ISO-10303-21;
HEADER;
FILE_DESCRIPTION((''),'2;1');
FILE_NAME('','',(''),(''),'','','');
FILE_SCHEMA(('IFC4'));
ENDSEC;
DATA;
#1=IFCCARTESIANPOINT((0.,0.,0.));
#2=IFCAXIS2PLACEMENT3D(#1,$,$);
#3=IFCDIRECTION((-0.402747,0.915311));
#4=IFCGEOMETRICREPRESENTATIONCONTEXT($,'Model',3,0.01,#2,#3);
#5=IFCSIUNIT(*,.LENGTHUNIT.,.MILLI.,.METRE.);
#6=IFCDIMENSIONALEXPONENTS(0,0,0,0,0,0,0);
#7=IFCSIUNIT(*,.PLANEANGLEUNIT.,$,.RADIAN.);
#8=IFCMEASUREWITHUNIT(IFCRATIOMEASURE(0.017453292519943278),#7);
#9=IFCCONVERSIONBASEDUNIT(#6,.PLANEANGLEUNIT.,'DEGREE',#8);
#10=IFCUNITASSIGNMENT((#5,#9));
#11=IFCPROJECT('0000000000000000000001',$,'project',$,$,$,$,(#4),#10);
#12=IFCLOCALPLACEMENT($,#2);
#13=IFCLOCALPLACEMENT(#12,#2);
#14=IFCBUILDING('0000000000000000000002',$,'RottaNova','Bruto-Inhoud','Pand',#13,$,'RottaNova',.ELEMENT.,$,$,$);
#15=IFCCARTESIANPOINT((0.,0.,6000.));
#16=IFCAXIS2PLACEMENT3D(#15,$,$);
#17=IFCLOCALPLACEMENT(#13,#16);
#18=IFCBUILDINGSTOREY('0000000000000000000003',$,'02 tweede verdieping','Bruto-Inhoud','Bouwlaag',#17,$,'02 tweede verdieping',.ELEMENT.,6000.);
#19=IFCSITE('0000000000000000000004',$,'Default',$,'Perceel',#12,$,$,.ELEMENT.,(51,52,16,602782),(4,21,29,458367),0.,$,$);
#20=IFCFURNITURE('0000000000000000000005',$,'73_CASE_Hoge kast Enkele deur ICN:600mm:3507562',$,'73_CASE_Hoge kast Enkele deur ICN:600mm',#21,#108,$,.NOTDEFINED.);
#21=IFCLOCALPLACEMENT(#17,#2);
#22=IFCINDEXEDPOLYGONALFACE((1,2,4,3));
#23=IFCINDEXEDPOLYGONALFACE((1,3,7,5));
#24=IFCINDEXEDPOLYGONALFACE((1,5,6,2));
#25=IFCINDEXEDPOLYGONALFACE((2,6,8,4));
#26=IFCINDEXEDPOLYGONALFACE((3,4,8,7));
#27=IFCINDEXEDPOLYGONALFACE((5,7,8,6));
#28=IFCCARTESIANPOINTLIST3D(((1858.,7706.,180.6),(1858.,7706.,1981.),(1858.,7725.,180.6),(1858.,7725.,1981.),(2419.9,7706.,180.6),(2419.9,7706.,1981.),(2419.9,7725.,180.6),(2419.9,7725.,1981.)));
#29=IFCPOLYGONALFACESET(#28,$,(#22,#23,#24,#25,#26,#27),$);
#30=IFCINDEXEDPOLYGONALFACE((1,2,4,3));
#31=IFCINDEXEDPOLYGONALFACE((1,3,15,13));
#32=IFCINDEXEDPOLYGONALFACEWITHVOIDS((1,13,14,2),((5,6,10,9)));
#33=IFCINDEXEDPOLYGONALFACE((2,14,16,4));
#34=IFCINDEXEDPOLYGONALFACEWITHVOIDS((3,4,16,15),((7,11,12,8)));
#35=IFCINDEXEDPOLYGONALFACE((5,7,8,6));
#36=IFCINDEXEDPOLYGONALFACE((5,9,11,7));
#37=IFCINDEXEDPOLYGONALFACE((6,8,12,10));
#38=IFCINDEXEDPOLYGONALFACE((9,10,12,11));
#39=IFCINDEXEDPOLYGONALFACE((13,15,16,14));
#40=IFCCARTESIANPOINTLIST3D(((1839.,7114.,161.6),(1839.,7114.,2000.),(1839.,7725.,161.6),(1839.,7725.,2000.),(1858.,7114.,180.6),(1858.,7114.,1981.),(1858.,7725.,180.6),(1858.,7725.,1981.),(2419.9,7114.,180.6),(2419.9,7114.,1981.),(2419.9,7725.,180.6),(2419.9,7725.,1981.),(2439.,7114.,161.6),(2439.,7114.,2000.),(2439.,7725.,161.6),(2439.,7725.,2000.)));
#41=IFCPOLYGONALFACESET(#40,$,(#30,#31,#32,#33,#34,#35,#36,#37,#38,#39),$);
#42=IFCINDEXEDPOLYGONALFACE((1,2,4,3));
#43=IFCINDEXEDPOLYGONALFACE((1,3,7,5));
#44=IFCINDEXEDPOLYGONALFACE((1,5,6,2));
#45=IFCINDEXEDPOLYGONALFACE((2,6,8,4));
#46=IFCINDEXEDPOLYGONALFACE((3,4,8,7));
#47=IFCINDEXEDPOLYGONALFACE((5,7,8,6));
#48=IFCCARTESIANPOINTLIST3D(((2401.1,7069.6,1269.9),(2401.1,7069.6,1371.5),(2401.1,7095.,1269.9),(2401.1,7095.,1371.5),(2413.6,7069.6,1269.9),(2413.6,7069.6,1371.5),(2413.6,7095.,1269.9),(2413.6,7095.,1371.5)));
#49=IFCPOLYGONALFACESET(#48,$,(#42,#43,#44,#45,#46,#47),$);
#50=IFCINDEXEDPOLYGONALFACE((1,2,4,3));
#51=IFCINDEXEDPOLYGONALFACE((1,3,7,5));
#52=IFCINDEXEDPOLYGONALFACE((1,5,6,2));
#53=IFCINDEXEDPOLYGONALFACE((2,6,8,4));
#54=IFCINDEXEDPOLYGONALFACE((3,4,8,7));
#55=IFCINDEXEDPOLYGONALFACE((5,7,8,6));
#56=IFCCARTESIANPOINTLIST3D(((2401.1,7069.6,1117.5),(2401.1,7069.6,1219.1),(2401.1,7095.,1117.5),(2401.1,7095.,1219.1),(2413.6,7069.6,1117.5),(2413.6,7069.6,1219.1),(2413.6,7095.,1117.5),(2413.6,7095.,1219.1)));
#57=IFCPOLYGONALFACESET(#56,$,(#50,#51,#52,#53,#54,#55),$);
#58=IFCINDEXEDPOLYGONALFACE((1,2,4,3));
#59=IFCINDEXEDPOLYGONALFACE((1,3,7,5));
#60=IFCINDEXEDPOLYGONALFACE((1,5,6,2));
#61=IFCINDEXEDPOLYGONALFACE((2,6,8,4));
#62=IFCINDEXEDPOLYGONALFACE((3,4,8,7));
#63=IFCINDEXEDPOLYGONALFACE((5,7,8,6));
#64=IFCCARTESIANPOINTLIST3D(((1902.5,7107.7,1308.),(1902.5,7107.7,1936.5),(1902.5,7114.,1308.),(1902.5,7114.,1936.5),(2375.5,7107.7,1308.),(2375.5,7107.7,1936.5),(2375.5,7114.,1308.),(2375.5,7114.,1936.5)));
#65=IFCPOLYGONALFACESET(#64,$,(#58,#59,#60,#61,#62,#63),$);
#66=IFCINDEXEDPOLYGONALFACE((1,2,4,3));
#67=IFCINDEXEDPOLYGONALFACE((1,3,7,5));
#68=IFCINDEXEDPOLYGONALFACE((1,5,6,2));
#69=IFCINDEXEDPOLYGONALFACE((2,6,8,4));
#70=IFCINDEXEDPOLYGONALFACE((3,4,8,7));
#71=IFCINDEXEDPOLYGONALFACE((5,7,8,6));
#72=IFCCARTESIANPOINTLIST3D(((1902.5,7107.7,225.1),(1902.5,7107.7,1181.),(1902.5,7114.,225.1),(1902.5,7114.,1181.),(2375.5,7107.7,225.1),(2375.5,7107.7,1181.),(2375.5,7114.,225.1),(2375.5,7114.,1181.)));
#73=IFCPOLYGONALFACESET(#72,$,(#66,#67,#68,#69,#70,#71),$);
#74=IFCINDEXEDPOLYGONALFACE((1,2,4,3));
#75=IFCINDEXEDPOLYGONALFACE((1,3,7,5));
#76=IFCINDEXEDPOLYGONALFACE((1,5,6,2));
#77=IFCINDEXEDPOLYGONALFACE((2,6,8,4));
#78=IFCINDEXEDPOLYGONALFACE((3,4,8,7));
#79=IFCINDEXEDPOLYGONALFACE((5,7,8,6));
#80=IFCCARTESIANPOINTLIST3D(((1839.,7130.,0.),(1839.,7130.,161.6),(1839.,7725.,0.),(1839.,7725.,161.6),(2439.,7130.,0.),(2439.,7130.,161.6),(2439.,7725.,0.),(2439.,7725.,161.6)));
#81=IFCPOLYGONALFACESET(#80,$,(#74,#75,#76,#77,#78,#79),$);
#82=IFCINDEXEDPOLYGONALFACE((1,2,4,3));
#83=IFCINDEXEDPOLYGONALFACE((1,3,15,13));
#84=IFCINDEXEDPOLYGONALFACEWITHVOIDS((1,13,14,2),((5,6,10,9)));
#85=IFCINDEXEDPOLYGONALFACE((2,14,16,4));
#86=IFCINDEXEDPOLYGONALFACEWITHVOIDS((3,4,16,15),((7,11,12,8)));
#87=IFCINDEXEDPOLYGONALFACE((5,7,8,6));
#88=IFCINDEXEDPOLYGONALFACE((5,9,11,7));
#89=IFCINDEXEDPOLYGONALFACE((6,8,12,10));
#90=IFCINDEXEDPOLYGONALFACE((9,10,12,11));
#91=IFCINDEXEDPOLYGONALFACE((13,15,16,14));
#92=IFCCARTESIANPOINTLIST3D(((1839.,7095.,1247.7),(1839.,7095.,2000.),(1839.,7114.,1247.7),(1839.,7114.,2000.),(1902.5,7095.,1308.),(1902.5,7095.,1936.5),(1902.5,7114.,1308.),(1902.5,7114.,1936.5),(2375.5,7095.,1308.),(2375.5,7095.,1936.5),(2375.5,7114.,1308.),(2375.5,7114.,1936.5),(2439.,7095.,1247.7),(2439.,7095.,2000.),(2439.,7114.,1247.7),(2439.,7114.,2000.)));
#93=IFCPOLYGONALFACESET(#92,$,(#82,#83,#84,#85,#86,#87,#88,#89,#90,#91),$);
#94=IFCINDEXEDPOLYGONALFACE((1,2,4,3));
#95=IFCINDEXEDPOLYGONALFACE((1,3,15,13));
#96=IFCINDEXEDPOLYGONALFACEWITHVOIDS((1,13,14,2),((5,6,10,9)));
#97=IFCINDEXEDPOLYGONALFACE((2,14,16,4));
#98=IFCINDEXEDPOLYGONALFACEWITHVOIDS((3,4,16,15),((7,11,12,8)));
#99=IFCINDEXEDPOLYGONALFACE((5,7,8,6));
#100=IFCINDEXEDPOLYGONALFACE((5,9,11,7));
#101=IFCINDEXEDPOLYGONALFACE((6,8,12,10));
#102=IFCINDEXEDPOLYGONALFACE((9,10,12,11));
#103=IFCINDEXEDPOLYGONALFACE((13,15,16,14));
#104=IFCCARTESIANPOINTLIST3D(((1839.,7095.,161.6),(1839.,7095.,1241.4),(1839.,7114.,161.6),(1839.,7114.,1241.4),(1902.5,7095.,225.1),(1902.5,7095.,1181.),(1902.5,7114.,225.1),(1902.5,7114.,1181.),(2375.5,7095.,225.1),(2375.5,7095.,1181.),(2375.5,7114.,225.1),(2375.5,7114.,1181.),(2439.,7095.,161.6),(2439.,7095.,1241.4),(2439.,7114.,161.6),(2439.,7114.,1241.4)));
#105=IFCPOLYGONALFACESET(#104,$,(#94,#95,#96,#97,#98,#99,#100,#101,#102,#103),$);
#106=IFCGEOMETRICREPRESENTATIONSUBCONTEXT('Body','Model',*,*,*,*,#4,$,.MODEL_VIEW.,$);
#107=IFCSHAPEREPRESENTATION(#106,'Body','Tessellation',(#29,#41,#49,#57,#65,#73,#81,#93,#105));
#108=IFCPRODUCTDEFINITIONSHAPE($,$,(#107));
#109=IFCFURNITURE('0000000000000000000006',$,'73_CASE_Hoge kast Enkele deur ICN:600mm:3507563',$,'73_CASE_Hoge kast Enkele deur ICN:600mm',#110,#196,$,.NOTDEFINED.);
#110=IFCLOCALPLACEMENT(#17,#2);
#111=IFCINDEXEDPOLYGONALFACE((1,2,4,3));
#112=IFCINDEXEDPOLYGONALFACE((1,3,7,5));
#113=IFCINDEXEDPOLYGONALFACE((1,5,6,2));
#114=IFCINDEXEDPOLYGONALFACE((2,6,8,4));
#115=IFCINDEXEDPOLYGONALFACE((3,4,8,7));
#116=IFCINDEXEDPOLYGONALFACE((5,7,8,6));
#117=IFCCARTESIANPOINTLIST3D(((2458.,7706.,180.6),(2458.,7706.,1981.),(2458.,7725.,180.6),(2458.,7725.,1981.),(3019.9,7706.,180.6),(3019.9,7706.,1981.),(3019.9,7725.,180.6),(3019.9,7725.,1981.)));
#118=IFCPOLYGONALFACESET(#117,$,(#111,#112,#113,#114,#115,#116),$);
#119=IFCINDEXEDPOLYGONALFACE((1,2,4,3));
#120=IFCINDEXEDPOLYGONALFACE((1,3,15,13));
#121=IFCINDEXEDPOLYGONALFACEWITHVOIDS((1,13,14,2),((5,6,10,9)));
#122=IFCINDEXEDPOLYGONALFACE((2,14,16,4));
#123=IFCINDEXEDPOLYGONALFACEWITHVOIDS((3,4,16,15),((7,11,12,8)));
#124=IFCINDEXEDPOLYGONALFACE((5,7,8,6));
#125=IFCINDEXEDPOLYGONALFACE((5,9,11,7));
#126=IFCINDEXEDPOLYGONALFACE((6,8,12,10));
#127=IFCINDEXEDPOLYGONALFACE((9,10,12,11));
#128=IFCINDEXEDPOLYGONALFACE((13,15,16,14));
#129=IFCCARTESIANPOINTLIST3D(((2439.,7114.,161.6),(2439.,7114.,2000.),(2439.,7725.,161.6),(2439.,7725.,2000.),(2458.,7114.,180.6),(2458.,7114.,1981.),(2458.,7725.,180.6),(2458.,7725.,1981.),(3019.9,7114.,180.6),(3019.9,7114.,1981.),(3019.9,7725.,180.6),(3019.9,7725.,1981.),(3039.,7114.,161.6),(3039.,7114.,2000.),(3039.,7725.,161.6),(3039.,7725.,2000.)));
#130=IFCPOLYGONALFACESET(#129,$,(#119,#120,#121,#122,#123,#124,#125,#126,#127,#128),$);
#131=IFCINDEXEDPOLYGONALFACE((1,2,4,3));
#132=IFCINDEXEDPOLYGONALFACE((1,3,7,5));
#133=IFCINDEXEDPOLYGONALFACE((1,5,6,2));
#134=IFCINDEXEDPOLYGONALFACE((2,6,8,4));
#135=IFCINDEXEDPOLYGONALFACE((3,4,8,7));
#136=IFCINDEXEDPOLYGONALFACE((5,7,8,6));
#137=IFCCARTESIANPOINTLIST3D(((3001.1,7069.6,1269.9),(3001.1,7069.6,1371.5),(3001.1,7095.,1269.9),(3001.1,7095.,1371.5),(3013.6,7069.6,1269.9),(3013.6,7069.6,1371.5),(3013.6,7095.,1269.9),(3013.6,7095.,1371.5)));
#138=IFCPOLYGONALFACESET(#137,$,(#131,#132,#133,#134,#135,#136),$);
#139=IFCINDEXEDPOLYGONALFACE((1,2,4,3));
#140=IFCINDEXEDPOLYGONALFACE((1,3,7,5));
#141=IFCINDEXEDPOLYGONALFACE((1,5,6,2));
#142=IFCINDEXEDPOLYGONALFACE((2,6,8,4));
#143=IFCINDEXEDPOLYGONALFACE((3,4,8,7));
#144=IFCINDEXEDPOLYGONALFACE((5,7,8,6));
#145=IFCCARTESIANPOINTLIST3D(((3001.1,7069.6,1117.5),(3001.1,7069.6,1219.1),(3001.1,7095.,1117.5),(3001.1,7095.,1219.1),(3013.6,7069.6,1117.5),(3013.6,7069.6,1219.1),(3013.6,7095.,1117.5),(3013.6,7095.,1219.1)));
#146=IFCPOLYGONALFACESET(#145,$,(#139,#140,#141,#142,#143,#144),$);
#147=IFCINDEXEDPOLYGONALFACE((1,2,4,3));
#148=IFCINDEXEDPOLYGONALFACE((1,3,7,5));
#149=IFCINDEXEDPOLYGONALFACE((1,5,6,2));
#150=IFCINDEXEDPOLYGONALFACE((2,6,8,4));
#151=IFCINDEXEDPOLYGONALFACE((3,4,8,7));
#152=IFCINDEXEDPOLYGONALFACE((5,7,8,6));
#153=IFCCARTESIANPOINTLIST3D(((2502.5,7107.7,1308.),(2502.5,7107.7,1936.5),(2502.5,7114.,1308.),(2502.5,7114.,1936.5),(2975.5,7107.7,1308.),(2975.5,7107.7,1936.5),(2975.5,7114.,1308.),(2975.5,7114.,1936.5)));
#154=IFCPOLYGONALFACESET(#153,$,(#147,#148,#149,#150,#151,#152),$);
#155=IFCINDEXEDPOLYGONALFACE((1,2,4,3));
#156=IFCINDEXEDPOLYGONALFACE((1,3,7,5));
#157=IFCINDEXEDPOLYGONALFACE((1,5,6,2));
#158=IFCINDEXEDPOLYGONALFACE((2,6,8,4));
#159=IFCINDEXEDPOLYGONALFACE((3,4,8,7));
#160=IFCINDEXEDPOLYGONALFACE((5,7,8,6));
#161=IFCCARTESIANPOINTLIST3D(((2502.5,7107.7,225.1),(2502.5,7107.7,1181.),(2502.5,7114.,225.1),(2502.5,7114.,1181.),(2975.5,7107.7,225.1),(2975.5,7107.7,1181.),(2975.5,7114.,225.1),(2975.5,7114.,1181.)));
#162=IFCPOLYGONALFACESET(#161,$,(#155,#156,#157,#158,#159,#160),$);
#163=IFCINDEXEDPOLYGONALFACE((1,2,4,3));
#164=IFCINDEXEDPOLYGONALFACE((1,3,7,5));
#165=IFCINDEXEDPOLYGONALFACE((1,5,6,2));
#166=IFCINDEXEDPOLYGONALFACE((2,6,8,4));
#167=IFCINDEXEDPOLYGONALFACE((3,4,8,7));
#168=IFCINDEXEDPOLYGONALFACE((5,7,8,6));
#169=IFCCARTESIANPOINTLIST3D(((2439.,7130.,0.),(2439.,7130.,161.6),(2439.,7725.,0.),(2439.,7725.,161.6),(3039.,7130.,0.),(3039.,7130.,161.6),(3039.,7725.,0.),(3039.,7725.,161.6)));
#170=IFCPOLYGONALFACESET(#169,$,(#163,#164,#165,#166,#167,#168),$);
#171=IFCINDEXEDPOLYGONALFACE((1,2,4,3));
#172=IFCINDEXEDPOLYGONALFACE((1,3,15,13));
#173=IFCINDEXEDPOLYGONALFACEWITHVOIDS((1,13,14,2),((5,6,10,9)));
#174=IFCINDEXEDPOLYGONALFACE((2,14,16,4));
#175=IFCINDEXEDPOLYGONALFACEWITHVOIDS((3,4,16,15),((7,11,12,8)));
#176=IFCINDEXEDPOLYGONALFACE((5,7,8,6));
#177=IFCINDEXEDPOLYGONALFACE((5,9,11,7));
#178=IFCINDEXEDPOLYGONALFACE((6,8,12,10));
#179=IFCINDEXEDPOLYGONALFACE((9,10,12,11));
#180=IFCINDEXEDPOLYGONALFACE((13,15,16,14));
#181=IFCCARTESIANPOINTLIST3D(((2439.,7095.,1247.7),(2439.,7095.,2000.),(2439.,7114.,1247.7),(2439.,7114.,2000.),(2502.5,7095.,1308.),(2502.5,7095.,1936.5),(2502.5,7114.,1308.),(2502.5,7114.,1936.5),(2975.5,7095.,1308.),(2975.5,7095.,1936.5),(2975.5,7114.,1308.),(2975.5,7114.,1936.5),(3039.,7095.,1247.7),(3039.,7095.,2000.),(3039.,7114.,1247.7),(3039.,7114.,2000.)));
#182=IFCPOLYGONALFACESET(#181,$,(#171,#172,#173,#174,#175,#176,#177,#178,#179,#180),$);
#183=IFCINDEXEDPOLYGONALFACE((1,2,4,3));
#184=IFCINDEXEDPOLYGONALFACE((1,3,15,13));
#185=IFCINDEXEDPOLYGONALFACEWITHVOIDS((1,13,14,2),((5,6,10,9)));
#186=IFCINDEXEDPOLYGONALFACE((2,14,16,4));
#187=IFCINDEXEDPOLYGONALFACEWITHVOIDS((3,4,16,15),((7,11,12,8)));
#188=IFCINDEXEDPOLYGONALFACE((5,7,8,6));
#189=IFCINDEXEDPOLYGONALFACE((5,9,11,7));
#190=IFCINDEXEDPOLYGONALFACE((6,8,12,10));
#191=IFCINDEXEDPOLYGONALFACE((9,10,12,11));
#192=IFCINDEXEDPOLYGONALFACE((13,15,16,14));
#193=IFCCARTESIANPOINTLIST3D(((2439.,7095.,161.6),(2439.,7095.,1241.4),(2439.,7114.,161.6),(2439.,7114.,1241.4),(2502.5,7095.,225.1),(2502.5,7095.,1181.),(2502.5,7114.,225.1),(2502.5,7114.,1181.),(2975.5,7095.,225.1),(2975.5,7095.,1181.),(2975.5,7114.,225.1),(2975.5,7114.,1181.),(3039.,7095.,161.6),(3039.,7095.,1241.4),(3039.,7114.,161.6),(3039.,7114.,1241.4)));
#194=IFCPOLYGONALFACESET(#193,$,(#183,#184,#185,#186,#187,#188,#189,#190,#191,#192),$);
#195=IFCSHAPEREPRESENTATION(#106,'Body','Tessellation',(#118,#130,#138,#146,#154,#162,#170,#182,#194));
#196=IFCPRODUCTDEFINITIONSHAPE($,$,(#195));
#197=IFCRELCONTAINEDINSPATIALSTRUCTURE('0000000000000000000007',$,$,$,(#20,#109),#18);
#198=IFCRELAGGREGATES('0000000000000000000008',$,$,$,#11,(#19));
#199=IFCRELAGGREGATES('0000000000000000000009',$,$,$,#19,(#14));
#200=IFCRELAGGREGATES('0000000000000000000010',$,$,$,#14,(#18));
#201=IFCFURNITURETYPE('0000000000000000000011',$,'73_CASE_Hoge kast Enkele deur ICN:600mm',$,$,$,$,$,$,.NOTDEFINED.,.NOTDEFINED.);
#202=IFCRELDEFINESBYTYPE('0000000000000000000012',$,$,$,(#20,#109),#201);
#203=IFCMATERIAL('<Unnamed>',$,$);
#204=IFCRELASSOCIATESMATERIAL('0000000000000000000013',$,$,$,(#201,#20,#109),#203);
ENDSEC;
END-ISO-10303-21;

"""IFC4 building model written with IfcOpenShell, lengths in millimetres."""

from ifc_helpers import new_model, entity, si_unit, converted_unit, direction, frame, frame_2d, origin, origin_2d_with_axis, place, context, subcontext, project, spatial, polyline, rectangle, outline, extrude, source, transform, mapped, material, type_object, type_shapes, element, save


model = new_model("IFC4")

# Units and contexts
model_context = context("Model", 3, precision=0.01, world=origin(), true_north=direction((-0.402747, 0.915311)))
body_context = subcontext(model_context, "Body", "Model", "MODEL_VIEW")
ifc_project = project(units=[si_unit("LENGTHUNIT", "METRE", prefix="MILLI"), converted_unit("PLANEANGLEUNIT", "DEGREE", entity("IfcRatioMeasure", 0.017453292519943278), si_unit("PLANEANGLEUNIT", "RADIAN"), dimensions=[0, 0, 0, 0, 0, 0, 0])], contexts=[model_context])

# Site, building, storey
site_placement = place(None, origin())
site = spatial("IfcSite", under=ifc_project, at=site_placement, Name="Default", ObjectType="Perceel", CompositionType="ELEMENT", RefLatitude=(51, 52, 16, 602782), RefLongitude=(4, 21, 29, 458367), RefElevation=0.0)
building_placement = place(site_placement, origin())
building = spatial("IfcBuilding", under=site, at=building_placement, Name="RottaNova", Description="Bruto-Inhoud", ObjectType="Pand", LongName="RottaNova", CompositionType="ELEMENT")
storey_placement = place(building_placement, frame((0.0, 0.0, 6000.0)))
storey = spatial("IfcBuildingStorey", under=building, at=storey_placement, Name="02 tweede verdieping", Description="Bruto-Inhoud", ObjectType="Bouwlaag", LongName="02 tweede verdieping", CompositionType="ELEMENT", Elevation=6000.0)

# Furniture
ifc_material_1 = material(Name="<Unnamed>")
furniture_type = type_object("IfcFurnitureType", Name="73_CASE_Hoge kast Enkele deur ICN:600mm", AssemblyPlace="NOTDEFINED", PredefinedType="NOTDEFINED", material=ifc_material_1)
shared_shape_1 = source(origin(), body_context, "Body", "SweptSolid", [
    extrude(rectangle(XDim=19.1, YDim=561.9, at=origin_2d_with_axis()), frame((18.7, -9.5, 180.6), z_axis=(0.0, 0.0, 1.0), x_axis=(0.0, 1.0, 0.0)), (0.0, 0.0, 1.0), 1800.3),
    extrude(outline(polyline([(-300.0, -919.2), (300.0, -919.2), (300.0, 919.2), (-300.0, 919.2), (-300.0, -919.2)]), holes=[polyline([(-280.9, 900.2), (281.0, 900.2), (281.0, -900.2), (-280.9, -900.2), (-280.9, 900.2)])]), frame((18.7, -610.9, 1080.8), z_axis=(0.0, 1.0, 0.0), x_axis=(-1.0, 0.0, 0.0)), (0.0, 0.0, 1.0), 610.9),
    extrude(rectangle(XDim=25.4, YDim=12.5, at=frame_2d((0.0, 0.0), x_axis=(1.0, 0.0))), frame((287.1, -642.7, 1269.9), z_axis=(0.0, 0.0, 1.0), x_axis=(0.0, 1.0, 0.0)), (0.0, 0.0, 1.0), 101.6),
    extrude(rectangle(XDim=25.4, YDim=12.5, at=frame_2d((0.0, 0.0), x_axis=(1.0, 0.0))), frame((287.1, -642.7, 1117.5), z_axis=(0.0, 0.0, 1.0), x_axis=(0.0, 1.0, 0.0)), (0.0, 0.0, 1.0), 101.6),
    extrude(rectangle(XDim=6.4, YDim=473.0, at=frame_2d((0.0, 0.0), x_axis=(1.0, 0.0))), frame((18.7, -614.1, 1308.0), z_axis=(0.0, 0.0, 1.0), x_axis=(0.0, 1.0, 0.0)), (0.0, 0.0, 1.0), 628.5),
    extrude(rectangle(XDim=6.4, YDim=473.0, at=origin_2d_with_axis()), frame((18.7, -614.1, 225.1), z_axis=(0.0, 0.0, 1.0), x_axis=(0.0, 1.0, 0.0)), (0.0, 0.0, 1.0), 956.0),
    extrude(rectangle(XDim=600.0, YDim=595.0, at=frame_2d((0.0, 0.0), x_axis=(1.0, 0.0))), frame((18.7, -297.5, 0.0), z_axis=(0.0, 0.0, 1.0), x_axis=(-1.0, 0.0, 0.0)), (0.0, 0.0, 1.0), 161.6),
    extrude(outline(polyline([(-376.1, -300.0), (376.1, -300.0), (376.1, 300.0), (-376.1, 300.0), (-376.1, -300.0)]), holes=[polyline([(-312.6, -236.5), (-312.6, 236.5), (315.8, 236.5), (315.8, -236.5), (-312.6, -236.5)])]), frame((18.7, -630.0, 1623.9), z_axis=(0.0, 1.0, 0.0), x_axis=(0.0, 0.0, -1.0)), (0.0, 0.0, 1.0), 19.1),
    extrude(outline(polyline([(-300.0, -539.9), (300.0, -539.9), (300.0, 539.9), (-300.0, 539.9), (-300.0, -539.9)]), holes=[polyline([(-236.5, 479.6), (236.5, 479.6), (236.5, -476.4), (-236.5, -476.4), (-236.5, 479.6)])]), frame((18.7, -630.0, 701.5), z_axis=(0.0, 1.0, 0.0), x_axis=(-1.0, 0.0, 0.0)), (0.0, 0.0, 1.0), 19.1),
])
type_shapes(furniture_type, [shared_shape_1])
for number, where, name in (
    (1, (2120.3, 7725.0, 0.0), "73_CASE_Hoge kast Enkele deur ICN:600mm:3507562"),
    (2, (2720.3, 7725.0, 0.0), "73_CASE_Hoge kast Enkele deur ICN:600mm:3507563"),
):
    element("IfcFurniture", number, at=place(storey_placement, frame(where)), inside=storey, type_object=furniture_type, material=ifc_material_1, Name=name, ObjectType="73_CASE_Hoge kast Enkele deur ICN:600mm", PredefinedType="NOTDEFINED", context=body_context, shape_type="MappedRepresentation", body=[
        mapped(shared_shape_1, transform((0.0, 0.0, 0.0), scale=1.0)),
    ])

save(model, "model.ifc")
